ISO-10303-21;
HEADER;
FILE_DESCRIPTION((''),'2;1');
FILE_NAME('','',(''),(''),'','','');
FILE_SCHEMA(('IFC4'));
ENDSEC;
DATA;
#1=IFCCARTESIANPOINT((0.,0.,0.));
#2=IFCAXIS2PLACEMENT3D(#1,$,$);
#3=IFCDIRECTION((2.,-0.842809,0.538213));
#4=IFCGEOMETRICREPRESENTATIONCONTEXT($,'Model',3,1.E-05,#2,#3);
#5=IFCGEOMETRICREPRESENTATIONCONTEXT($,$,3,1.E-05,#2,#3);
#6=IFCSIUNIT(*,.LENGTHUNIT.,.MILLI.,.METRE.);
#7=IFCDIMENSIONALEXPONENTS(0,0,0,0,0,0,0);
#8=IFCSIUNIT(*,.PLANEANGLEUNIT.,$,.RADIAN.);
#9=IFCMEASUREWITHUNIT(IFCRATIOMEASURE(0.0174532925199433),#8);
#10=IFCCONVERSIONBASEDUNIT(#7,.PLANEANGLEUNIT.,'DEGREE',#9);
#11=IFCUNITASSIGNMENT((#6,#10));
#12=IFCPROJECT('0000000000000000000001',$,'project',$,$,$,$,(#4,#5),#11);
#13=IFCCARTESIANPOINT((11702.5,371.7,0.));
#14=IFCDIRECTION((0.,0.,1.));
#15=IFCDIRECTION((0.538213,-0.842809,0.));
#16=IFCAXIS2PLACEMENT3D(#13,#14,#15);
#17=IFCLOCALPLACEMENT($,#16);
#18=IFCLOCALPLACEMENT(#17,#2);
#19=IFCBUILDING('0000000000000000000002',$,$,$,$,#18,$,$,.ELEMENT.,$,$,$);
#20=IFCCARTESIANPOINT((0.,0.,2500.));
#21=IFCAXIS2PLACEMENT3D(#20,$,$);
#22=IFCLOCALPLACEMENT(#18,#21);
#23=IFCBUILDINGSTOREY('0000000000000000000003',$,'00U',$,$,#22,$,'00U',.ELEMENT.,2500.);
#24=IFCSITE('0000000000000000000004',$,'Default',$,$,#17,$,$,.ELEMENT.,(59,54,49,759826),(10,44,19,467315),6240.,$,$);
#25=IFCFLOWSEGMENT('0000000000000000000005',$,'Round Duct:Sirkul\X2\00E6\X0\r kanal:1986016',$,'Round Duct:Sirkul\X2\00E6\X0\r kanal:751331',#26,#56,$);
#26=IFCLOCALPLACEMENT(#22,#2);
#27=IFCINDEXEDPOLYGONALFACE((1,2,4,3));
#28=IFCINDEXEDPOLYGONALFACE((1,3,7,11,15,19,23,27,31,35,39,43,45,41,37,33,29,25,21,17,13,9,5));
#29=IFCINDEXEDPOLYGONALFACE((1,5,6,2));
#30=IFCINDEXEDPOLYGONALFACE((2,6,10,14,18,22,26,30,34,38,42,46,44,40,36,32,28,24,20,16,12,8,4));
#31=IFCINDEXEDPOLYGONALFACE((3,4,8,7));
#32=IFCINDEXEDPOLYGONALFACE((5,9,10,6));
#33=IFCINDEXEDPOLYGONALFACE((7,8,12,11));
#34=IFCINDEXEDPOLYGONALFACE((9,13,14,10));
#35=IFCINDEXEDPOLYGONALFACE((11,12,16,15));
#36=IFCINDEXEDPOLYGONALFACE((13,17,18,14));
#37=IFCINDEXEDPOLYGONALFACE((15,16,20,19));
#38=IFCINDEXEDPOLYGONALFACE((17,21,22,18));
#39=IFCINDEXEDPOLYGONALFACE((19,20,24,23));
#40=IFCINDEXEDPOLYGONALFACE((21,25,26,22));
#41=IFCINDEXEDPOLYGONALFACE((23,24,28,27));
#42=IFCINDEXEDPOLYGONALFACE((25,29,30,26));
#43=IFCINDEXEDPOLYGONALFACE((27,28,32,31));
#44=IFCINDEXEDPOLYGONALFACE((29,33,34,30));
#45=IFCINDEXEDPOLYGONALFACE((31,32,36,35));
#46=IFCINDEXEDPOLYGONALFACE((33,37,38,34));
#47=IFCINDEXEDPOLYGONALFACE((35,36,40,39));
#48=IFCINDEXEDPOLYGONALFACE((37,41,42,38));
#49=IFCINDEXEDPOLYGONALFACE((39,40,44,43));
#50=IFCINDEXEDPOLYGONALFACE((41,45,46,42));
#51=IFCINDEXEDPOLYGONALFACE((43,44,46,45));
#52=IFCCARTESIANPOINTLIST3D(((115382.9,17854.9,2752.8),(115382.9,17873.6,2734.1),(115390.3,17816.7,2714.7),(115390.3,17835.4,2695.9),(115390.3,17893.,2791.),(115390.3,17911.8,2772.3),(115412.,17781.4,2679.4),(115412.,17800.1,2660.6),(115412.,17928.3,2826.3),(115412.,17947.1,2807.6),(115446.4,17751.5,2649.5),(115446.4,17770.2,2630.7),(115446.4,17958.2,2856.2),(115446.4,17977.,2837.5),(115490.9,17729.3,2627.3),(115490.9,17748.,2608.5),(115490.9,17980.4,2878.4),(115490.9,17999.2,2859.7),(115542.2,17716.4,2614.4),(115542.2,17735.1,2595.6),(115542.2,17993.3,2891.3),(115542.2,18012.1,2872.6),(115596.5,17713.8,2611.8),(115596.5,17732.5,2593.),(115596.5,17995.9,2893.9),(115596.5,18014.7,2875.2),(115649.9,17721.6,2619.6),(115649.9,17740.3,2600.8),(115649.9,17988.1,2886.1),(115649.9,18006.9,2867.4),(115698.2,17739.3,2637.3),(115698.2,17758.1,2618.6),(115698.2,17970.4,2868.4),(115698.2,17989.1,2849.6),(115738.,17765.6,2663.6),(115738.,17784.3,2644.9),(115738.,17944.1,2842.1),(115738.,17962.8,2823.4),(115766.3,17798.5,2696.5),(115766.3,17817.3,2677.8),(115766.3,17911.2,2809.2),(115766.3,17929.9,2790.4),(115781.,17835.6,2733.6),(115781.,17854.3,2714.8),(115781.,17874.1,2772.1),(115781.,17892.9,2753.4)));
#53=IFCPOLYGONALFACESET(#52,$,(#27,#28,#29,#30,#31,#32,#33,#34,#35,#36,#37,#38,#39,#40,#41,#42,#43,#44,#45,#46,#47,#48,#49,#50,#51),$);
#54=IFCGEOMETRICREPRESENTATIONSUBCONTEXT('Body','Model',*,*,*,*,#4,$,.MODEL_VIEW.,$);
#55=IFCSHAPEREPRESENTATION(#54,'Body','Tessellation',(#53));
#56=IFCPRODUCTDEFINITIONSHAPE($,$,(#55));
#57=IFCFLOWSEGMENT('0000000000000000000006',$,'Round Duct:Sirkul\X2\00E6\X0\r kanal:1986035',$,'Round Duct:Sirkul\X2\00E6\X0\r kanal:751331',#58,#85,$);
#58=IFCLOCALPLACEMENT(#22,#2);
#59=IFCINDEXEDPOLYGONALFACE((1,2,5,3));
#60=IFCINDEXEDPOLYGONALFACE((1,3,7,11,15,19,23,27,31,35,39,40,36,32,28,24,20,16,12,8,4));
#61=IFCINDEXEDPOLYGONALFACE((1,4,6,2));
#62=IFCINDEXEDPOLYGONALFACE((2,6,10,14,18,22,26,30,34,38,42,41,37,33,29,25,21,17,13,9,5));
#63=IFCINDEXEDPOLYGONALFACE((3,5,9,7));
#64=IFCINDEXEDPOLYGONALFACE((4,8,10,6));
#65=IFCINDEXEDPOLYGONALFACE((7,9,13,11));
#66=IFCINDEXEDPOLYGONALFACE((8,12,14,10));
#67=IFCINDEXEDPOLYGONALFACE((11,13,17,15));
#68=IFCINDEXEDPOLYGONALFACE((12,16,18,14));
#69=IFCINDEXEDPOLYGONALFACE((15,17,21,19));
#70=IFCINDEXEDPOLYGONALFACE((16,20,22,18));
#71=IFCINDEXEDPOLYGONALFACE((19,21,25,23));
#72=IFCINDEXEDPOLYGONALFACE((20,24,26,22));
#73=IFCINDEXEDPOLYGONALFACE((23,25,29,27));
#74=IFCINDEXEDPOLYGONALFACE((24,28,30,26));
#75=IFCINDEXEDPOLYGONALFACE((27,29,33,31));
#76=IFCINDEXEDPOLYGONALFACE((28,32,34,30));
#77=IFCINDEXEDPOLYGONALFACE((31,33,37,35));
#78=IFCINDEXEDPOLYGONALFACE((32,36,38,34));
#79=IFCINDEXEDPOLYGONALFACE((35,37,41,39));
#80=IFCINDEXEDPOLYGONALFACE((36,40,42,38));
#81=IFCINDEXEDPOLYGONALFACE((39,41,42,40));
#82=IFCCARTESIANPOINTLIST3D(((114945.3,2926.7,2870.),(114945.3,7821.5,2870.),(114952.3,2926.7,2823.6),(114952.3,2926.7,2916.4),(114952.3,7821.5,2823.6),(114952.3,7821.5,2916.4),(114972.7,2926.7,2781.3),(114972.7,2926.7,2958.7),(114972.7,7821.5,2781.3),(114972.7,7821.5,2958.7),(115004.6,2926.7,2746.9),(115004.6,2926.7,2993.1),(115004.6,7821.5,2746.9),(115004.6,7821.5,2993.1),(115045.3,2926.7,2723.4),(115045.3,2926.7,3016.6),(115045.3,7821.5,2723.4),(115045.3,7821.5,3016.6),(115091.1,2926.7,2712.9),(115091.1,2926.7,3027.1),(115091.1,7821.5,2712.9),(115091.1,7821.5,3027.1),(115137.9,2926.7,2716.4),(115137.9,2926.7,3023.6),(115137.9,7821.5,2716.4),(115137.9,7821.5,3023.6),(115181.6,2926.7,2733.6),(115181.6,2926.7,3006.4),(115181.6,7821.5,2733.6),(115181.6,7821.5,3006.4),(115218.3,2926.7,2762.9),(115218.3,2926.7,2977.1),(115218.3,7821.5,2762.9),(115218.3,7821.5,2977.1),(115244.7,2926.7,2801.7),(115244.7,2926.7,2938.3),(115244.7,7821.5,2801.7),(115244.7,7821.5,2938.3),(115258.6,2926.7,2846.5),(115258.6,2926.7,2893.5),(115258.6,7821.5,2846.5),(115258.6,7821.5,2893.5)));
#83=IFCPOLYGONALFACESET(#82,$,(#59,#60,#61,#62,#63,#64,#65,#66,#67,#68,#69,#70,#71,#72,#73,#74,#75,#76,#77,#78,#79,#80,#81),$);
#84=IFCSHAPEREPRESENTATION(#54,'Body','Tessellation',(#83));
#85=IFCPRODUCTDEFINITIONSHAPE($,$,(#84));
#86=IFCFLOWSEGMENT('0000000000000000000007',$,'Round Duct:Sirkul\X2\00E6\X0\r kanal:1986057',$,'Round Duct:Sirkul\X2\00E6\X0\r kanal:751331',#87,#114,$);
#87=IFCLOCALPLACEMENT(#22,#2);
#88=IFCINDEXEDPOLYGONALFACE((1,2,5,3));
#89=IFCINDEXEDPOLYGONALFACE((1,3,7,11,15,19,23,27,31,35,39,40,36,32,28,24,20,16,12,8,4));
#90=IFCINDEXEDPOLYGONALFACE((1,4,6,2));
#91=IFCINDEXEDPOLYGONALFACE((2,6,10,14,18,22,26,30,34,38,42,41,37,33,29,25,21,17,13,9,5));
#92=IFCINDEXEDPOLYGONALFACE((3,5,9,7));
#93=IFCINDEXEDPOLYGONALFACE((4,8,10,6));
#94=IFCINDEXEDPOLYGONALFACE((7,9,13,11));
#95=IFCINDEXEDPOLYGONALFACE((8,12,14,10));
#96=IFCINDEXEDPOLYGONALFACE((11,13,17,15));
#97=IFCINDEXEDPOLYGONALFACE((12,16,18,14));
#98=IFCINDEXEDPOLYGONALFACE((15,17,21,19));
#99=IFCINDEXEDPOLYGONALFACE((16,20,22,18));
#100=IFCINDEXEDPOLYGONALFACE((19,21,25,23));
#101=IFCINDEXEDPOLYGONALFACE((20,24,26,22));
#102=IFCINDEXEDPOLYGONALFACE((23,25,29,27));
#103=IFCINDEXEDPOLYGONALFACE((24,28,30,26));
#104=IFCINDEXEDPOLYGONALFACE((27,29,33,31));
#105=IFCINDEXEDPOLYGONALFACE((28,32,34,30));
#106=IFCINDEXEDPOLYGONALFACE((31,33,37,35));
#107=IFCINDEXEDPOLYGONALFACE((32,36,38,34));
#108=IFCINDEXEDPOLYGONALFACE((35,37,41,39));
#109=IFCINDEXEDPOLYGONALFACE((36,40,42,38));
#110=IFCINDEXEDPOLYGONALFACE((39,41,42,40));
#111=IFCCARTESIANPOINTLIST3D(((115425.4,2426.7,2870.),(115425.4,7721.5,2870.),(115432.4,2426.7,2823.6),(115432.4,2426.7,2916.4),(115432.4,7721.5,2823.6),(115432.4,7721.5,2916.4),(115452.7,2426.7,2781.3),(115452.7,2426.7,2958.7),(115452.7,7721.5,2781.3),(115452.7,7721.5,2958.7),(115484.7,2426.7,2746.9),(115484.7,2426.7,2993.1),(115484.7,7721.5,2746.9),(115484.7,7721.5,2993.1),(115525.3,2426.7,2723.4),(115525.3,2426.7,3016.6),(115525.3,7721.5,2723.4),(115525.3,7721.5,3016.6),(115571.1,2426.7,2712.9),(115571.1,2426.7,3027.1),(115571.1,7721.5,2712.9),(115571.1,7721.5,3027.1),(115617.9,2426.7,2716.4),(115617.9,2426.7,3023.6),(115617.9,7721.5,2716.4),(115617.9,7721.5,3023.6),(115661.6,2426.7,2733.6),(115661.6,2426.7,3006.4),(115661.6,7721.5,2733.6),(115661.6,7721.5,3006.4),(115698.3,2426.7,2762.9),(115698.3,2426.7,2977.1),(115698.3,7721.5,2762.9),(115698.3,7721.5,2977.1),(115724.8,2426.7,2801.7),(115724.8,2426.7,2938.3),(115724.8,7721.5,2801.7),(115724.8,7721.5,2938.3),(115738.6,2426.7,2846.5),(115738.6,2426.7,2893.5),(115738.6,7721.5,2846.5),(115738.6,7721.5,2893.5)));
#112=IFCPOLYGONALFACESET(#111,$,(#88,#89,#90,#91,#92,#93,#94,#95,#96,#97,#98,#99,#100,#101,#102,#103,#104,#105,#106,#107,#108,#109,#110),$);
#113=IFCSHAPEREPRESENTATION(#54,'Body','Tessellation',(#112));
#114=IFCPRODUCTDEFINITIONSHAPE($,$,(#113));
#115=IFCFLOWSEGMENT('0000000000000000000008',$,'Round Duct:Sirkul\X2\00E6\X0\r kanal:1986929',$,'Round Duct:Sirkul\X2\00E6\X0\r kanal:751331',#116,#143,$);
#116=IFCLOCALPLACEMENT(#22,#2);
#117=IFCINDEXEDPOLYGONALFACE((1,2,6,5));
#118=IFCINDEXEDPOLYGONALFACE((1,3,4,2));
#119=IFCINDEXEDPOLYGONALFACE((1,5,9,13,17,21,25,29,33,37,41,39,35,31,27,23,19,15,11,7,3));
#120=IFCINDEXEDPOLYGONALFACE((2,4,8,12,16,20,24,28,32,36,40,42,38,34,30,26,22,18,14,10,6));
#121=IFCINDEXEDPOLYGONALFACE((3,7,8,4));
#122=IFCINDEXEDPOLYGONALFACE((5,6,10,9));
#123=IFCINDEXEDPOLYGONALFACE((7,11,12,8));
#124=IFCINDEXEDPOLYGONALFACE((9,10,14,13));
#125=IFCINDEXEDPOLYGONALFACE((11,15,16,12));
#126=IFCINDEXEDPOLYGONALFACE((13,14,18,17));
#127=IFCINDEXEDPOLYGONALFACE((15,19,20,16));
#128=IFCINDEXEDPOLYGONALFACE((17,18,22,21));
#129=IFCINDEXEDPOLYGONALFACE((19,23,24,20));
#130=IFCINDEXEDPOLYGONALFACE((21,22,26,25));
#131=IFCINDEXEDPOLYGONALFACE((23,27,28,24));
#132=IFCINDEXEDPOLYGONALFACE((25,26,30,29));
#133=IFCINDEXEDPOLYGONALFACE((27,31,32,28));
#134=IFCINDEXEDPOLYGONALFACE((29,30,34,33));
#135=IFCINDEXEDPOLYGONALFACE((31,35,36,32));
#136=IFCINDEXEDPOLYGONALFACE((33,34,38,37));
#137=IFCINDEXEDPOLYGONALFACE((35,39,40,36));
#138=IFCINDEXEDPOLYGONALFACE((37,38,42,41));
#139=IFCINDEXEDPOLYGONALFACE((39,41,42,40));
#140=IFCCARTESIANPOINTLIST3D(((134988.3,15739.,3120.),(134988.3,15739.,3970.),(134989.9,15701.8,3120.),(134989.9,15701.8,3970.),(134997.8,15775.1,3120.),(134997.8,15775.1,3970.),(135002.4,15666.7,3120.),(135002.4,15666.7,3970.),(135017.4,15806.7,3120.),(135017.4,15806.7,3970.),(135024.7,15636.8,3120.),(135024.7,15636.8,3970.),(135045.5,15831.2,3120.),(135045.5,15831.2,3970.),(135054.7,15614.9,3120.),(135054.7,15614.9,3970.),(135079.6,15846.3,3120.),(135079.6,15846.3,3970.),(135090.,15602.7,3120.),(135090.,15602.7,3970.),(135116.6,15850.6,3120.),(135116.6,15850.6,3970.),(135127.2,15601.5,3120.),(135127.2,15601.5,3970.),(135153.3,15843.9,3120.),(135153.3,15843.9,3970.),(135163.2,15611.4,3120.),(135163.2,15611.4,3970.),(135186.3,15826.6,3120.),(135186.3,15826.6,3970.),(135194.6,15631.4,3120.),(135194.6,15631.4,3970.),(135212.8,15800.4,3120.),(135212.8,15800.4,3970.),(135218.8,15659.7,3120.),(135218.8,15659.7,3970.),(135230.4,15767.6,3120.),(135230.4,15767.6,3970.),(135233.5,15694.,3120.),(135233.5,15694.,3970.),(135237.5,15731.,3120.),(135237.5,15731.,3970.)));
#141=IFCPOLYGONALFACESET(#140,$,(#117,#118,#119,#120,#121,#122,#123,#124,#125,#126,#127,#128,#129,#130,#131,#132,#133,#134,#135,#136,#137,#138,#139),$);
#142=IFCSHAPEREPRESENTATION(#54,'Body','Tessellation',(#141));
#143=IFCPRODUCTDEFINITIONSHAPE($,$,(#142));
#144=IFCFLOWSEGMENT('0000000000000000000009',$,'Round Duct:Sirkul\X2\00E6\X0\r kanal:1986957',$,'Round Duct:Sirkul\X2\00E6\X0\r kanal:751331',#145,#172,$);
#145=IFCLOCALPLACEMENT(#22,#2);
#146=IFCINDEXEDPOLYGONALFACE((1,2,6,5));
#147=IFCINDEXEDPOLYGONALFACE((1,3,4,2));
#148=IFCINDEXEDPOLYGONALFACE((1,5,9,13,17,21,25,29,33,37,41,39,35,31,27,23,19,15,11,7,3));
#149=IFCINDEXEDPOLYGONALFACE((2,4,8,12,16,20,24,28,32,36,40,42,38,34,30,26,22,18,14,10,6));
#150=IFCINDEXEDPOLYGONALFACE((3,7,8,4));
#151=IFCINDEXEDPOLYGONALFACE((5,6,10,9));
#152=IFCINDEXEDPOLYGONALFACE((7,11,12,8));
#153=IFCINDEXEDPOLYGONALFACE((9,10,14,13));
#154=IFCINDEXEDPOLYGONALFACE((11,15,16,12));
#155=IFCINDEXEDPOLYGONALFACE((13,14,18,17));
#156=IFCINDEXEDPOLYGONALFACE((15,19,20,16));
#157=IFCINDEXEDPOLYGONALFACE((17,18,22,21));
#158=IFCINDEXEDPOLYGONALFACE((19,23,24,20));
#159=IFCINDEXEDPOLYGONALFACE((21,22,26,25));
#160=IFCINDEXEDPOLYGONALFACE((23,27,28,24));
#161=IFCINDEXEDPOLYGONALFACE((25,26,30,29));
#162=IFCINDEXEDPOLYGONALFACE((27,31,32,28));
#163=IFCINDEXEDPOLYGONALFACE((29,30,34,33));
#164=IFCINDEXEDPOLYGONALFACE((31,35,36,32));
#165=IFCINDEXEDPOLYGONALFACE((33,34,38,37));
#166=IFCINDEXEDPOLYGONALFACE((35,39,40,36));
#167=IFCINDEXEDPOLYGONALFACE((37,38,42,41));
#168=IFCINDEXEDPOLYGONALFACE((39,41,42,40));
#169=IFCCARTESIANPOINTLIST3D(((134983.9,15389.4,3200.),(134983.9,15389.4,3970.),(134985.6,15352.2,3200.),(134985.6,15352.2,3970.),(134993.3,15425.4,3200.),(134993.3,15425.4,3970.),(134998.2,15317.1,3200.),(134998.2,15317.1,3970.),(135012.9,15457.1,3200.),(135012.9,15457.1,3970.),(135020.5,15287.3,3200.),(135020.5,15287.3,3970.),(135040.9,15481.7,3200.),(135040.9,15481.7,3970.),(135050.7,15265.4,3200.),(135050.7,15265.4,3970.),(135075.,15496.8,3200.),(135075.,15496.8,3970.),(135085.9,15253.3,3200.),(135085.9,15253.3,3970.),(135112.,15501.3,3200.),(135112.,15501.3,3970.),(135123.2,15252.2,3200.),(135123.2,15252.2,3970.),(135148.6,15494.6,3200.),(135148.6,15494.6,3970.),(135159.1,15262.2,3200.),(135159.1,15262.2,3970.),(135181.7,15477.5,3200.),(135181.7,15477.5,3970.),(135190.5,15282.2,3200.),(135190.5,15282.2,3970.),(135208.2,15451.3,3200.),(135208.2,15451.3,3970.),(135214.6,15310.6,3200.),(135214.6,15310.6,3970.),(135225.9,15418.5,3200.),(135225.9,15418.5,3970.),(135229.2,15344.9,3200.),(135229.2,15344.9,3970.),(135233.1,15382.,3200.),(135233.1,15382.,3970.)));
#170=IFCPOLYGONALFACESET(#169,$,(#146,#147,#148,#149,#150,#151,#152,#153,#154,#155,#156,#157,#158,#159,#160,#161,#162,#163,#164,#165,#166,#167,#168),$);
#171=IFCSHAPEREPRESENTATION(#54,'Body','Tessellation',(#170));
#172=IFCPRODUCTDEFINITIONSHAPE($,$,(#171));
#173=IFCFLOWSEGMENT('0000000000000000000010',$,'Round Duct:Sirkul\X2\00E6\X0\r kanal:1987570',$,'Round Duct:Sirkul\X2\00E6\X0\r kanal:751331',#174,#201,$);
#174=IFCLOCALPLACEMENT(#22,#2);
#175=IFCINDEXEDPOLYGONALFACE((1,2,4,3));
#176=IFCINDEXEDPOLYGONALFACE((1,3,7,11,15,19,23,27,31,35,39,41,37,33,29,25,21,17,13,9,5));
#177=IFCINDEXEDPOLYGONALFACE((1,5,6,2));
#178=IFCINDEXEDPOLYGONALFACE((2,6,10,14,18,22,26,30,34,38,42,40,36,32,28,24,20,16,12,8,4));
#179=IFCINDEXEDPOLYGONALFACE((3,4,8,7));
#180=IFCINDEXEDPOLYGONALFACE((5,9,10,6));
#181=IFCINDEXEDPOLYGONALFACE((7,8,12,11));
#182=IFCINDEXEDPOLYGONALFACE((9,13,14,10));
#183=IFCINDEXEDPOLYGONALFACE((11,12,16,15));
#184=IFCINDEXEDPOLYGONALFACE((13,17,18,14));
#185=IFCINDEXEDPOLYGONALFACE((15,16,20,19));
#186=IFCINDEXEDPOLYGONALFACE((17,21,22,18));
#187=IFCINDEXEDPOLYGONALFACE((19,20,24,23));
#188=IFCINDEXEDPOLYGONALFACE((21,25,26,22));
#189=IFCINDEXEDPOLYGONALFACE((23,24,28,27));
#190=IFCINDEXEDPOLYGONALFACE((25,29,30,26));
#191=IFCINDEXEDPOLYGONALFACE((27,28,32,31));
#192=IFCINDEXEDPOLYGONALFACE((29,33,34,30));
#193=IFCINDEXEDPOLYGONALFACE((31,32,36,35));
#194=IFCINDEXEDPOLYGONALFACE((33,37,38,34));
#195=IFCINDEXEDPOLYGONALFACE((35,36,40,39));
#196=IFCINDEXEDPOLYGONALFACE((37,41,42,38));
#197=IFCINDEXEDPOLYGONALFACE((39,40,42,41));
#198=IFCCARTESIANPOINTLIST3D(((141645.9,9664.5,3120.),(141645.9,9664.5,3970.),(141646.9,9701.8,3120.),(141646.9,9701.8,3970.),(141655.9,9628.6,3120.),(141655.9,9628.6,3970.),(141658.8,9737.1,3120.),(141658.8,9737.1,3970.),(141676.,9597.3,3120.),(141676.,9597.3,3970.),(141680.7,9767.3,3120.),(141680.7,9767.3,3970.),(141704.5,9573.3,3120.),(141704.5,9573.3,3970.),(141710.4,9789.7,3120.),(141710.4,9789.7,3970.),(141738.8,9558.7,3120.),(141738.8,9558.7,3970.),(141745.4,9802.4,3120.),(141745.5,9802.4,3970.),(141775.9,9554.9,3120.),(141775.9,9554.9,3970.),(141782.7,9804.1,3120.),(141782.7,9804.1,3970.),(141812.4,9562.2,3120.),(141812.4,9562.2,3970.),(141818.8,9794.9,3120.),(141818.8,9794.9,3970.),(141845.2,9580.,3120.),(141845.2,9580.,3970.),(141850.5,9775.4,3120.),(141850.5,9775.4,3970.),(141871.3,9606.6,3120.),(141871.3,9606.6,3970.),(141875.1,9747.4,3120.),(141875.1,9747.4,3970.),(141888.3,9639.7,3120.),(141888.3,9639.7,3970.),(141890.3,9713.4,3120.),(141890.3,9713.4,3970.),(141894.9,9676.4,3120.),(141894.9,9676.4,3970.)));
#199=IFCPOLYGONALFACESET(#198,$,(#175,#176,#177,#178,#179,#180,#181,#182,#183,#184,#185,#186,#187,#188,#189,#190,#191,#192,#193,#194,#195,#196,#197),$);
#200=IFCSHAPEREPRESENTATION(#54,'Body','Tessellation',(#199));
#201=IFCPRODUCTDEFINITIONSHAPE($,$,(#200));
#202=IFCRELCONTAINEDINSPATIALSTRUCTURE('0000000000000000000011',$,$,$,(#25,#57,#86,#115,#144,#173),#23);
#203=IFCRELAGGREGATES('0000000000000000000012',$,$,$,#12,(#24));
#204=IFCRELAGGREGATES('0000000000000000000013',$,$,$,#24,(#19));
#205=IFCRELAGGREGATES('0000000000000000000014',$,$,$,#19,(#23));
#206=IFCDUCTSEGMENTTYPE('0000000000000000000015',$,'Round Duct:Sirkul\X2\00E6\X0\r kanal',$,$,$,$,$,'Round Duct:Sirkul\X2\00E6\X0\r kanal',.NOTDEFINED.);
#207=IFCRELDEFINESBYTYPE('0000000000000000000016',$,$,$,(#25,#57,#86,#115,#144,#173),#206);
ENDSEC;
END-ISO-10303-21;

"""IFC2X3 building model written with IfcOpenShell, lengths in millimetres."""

from ifc_helpers import new_model, entity, si_unit, converted_unit, direction, frame, frame_2d, origin, origin_2d_with_axis, place, context, subcontext, project, spatial, circle, extrude, type_object, element, save


model = new_model("IFC2X3")

# Units and contexts
model_context = context("Model", 3, precision=1e-05, world=origin(), true_north=direction((2.0, -0.842809, 0.538213)))
context_of_model = context(None, 3, precision=1e-05, world=origin(), true_north=direction((2.0, -0.842809, 0.538213)))
body_context = subcontext(model_context, "Body", "Model", "MODEL_VIEW")
ifc_project = project(units=[si_unit("LENGTHUNIT", "METRE", prefix="MILLI"), converted_unit("PLANEANGLEUNIT", "DEGREE", entity("IfcRatioMeasure", 0.0174532925199433), si_unit("PLANEANGLEUNIT", "RADIAN"), dimensions=[0, 0, 0, 0, 0, 0, 0])], contexts=[model_context, context_of_model])

# Site, building, storey
site_placement = place(None, frame((11702.5, 371.7, 0.0), z_axis=(0.0, 0.0, 1.0), x_axis=(0.538213, -0.842809, 0.0)))
site = spatial("IfcSite", under=ifc_project, at=site_placement, Name="Default", CompositionType="ELEMENT", RefLatitude=(59, 54, 49, 759826), RefLongitude=(10, 44, 19, 467315), RefElevation=6240.0)
building_placement = place(site_placement, origin())
building = spatial("IfcBuilding", under=site, at=building_placement, CompositionType="ELEMENT")
storey_placement = place(building_placement, frame((0.0, 0.0, 2500.0)))
storey = spatial("IfcBuildingStorey", under=building, at=storey_placement, Name="00U", LongName="00U", CompositionType="ELEMENT", Elevation=2500.0)

# Flow segments
duct_segment_type_1 = type_object("IfcDuctSegmentType", Name="Round Duct:Sirkulær kanal", ElementType="Round Duct:Sirkulær kanal", PredefinedType="NOTDEFINED")
flow_segment_1_placement = place(storey_placement, origin())
element("IfcFlowSegment", 1, at=flow_segment_1_placement, inside=storey, type_object=duct_segment_type_1, Name="Round Duct:Sirkulær kanal:1986016", ObjectType="Round Duct:Sirkulær kanal:751331", context=body_context, shape_type="SweptSolid", body=[
    extrude(circle(Radius=200.0, at=frame_2d((0.0, 0.0), x_axis=(1.0, 0.0))), frame((115582.9, 17873.6, 2734.1), z_axis=(0.0, -0.707107, 0.707107), x_axis=(-1.0, 0.0, 0.0)), (0.0, 0.0, 1.0), 26.5),
])
flow_segment_2_placement = place(storey_placement, origin())
element("IfcFlowSegment", 2, at=flow_segment_2_placement, inside=storey, type_object=duct_segment_type_1, Name="Round Duct:Sirkulær kanal:1986035", ObjectType="Round Duct:Sirkulær kanal:751331", context=body_context, shape_type="SweptSolid", body=[
    extrude(circle(Radius=157.5, at=origin_2d_with_axis()), frame((115102.8, 2926.7, 2870.0), z_axis=(0.0, 1.0, 0.0), x_axis=(-1.0, 0.0, 0.0)), (0.0, 0.0, 1.0), 4894.8),
])
flow_segment_3_placement = place(storey_placement, origin())
element("IfcFlowSegment", 3, at=flow_segment_3_placement, inside=storey, type_object=duct_segment_type_1, Name="Round Duct:Sirkulær kanal:1986057", ObjectType="Round Duct:Sirkulær kanal:751331", context=body_context, shape_type="SweptSolid", body=[
    extrude(circle(Radius=157.5, at=origin_2d_with_axis()), frame((115582.9, 2426.7, 2870.0), z_axis=(0.0, 1.0, 0.0), x_axis=(-1.0, 0.0, 0.0)), (0.0, 0.0, 1.0), 5294.8),
])
flow_segment_4_placement = place(storey_placement, origin())
element("IfcFlowSegment", 4, at=flow_segment_4_placement, inside=storey, type_object=duct_segment_type_1, Name="Round Duct:Sirkulær kanal:1986929", ObjectType="Round Duct:Sirkulær kanal:751331", context=body_context, shape_type="SweptSolid", body=[
    extrude(circle(Radius=125.0, at=frame_2d((0.0, 0.0), x_axis=(1.0, 0.0))), frame((135112.6, 15725.7, 3120.0), z_axis=(0.000001, 0.0, 1.0), x_axis=(-0.46271, -0.88651, 0.0)), (0.0, 0.0, 1.0), 850.0),
])
flow_segment_5_placement = place(storey_placement, origin())
element("IfcFlowSegment", 5, at=flow_segment_5_placement, inside=storey, type_object=duct_segment_type_1, Name="Round Duct:Sirkulær kanal:1986957", ObjectType="Round Duct:Sirkulær kanal:751331", context=body_context, shape_type="SweptSolid", body=[
    extrude(circle(Radius=125.0, at=frame_2d((0.0, 0.0), x_axis=(1.0, 0.0))), frame((135108.2, 15376.3, 3200.0), z_axis=(0.000001, 0.0, 1.0), x_axis=(0.967876, -0.251429, -0.000001)), (0.0, 0.0, 1.0), 770.0),
])
flow_segment_6_placement = place(storey_placement, origin())
element("IfcFlowSegment", 6, at=flow_segment_6_placement, inside=storey, type_object=duct_segment_type_1, Name="Round Duct:Sirkulær kanal:1987570", ObjectType="Round Duct:Sirkulær kanal:751331", context=body_context, shape_type="SweptSolid", body=[
    extrude(circle(Radius=125.0, at=frame_2d((0.0, 0.0), x_axis=(1.0, 0.0))), frame((141769.9, 9679.8, 3120.0), z_axis=(0.000001, 0.0, 1.0), x_axis=(0.999628, -0.02726, -0.000001)), (0.0, 0.0, 1.0), 850.0),
])

save(model, "model.ifc")
